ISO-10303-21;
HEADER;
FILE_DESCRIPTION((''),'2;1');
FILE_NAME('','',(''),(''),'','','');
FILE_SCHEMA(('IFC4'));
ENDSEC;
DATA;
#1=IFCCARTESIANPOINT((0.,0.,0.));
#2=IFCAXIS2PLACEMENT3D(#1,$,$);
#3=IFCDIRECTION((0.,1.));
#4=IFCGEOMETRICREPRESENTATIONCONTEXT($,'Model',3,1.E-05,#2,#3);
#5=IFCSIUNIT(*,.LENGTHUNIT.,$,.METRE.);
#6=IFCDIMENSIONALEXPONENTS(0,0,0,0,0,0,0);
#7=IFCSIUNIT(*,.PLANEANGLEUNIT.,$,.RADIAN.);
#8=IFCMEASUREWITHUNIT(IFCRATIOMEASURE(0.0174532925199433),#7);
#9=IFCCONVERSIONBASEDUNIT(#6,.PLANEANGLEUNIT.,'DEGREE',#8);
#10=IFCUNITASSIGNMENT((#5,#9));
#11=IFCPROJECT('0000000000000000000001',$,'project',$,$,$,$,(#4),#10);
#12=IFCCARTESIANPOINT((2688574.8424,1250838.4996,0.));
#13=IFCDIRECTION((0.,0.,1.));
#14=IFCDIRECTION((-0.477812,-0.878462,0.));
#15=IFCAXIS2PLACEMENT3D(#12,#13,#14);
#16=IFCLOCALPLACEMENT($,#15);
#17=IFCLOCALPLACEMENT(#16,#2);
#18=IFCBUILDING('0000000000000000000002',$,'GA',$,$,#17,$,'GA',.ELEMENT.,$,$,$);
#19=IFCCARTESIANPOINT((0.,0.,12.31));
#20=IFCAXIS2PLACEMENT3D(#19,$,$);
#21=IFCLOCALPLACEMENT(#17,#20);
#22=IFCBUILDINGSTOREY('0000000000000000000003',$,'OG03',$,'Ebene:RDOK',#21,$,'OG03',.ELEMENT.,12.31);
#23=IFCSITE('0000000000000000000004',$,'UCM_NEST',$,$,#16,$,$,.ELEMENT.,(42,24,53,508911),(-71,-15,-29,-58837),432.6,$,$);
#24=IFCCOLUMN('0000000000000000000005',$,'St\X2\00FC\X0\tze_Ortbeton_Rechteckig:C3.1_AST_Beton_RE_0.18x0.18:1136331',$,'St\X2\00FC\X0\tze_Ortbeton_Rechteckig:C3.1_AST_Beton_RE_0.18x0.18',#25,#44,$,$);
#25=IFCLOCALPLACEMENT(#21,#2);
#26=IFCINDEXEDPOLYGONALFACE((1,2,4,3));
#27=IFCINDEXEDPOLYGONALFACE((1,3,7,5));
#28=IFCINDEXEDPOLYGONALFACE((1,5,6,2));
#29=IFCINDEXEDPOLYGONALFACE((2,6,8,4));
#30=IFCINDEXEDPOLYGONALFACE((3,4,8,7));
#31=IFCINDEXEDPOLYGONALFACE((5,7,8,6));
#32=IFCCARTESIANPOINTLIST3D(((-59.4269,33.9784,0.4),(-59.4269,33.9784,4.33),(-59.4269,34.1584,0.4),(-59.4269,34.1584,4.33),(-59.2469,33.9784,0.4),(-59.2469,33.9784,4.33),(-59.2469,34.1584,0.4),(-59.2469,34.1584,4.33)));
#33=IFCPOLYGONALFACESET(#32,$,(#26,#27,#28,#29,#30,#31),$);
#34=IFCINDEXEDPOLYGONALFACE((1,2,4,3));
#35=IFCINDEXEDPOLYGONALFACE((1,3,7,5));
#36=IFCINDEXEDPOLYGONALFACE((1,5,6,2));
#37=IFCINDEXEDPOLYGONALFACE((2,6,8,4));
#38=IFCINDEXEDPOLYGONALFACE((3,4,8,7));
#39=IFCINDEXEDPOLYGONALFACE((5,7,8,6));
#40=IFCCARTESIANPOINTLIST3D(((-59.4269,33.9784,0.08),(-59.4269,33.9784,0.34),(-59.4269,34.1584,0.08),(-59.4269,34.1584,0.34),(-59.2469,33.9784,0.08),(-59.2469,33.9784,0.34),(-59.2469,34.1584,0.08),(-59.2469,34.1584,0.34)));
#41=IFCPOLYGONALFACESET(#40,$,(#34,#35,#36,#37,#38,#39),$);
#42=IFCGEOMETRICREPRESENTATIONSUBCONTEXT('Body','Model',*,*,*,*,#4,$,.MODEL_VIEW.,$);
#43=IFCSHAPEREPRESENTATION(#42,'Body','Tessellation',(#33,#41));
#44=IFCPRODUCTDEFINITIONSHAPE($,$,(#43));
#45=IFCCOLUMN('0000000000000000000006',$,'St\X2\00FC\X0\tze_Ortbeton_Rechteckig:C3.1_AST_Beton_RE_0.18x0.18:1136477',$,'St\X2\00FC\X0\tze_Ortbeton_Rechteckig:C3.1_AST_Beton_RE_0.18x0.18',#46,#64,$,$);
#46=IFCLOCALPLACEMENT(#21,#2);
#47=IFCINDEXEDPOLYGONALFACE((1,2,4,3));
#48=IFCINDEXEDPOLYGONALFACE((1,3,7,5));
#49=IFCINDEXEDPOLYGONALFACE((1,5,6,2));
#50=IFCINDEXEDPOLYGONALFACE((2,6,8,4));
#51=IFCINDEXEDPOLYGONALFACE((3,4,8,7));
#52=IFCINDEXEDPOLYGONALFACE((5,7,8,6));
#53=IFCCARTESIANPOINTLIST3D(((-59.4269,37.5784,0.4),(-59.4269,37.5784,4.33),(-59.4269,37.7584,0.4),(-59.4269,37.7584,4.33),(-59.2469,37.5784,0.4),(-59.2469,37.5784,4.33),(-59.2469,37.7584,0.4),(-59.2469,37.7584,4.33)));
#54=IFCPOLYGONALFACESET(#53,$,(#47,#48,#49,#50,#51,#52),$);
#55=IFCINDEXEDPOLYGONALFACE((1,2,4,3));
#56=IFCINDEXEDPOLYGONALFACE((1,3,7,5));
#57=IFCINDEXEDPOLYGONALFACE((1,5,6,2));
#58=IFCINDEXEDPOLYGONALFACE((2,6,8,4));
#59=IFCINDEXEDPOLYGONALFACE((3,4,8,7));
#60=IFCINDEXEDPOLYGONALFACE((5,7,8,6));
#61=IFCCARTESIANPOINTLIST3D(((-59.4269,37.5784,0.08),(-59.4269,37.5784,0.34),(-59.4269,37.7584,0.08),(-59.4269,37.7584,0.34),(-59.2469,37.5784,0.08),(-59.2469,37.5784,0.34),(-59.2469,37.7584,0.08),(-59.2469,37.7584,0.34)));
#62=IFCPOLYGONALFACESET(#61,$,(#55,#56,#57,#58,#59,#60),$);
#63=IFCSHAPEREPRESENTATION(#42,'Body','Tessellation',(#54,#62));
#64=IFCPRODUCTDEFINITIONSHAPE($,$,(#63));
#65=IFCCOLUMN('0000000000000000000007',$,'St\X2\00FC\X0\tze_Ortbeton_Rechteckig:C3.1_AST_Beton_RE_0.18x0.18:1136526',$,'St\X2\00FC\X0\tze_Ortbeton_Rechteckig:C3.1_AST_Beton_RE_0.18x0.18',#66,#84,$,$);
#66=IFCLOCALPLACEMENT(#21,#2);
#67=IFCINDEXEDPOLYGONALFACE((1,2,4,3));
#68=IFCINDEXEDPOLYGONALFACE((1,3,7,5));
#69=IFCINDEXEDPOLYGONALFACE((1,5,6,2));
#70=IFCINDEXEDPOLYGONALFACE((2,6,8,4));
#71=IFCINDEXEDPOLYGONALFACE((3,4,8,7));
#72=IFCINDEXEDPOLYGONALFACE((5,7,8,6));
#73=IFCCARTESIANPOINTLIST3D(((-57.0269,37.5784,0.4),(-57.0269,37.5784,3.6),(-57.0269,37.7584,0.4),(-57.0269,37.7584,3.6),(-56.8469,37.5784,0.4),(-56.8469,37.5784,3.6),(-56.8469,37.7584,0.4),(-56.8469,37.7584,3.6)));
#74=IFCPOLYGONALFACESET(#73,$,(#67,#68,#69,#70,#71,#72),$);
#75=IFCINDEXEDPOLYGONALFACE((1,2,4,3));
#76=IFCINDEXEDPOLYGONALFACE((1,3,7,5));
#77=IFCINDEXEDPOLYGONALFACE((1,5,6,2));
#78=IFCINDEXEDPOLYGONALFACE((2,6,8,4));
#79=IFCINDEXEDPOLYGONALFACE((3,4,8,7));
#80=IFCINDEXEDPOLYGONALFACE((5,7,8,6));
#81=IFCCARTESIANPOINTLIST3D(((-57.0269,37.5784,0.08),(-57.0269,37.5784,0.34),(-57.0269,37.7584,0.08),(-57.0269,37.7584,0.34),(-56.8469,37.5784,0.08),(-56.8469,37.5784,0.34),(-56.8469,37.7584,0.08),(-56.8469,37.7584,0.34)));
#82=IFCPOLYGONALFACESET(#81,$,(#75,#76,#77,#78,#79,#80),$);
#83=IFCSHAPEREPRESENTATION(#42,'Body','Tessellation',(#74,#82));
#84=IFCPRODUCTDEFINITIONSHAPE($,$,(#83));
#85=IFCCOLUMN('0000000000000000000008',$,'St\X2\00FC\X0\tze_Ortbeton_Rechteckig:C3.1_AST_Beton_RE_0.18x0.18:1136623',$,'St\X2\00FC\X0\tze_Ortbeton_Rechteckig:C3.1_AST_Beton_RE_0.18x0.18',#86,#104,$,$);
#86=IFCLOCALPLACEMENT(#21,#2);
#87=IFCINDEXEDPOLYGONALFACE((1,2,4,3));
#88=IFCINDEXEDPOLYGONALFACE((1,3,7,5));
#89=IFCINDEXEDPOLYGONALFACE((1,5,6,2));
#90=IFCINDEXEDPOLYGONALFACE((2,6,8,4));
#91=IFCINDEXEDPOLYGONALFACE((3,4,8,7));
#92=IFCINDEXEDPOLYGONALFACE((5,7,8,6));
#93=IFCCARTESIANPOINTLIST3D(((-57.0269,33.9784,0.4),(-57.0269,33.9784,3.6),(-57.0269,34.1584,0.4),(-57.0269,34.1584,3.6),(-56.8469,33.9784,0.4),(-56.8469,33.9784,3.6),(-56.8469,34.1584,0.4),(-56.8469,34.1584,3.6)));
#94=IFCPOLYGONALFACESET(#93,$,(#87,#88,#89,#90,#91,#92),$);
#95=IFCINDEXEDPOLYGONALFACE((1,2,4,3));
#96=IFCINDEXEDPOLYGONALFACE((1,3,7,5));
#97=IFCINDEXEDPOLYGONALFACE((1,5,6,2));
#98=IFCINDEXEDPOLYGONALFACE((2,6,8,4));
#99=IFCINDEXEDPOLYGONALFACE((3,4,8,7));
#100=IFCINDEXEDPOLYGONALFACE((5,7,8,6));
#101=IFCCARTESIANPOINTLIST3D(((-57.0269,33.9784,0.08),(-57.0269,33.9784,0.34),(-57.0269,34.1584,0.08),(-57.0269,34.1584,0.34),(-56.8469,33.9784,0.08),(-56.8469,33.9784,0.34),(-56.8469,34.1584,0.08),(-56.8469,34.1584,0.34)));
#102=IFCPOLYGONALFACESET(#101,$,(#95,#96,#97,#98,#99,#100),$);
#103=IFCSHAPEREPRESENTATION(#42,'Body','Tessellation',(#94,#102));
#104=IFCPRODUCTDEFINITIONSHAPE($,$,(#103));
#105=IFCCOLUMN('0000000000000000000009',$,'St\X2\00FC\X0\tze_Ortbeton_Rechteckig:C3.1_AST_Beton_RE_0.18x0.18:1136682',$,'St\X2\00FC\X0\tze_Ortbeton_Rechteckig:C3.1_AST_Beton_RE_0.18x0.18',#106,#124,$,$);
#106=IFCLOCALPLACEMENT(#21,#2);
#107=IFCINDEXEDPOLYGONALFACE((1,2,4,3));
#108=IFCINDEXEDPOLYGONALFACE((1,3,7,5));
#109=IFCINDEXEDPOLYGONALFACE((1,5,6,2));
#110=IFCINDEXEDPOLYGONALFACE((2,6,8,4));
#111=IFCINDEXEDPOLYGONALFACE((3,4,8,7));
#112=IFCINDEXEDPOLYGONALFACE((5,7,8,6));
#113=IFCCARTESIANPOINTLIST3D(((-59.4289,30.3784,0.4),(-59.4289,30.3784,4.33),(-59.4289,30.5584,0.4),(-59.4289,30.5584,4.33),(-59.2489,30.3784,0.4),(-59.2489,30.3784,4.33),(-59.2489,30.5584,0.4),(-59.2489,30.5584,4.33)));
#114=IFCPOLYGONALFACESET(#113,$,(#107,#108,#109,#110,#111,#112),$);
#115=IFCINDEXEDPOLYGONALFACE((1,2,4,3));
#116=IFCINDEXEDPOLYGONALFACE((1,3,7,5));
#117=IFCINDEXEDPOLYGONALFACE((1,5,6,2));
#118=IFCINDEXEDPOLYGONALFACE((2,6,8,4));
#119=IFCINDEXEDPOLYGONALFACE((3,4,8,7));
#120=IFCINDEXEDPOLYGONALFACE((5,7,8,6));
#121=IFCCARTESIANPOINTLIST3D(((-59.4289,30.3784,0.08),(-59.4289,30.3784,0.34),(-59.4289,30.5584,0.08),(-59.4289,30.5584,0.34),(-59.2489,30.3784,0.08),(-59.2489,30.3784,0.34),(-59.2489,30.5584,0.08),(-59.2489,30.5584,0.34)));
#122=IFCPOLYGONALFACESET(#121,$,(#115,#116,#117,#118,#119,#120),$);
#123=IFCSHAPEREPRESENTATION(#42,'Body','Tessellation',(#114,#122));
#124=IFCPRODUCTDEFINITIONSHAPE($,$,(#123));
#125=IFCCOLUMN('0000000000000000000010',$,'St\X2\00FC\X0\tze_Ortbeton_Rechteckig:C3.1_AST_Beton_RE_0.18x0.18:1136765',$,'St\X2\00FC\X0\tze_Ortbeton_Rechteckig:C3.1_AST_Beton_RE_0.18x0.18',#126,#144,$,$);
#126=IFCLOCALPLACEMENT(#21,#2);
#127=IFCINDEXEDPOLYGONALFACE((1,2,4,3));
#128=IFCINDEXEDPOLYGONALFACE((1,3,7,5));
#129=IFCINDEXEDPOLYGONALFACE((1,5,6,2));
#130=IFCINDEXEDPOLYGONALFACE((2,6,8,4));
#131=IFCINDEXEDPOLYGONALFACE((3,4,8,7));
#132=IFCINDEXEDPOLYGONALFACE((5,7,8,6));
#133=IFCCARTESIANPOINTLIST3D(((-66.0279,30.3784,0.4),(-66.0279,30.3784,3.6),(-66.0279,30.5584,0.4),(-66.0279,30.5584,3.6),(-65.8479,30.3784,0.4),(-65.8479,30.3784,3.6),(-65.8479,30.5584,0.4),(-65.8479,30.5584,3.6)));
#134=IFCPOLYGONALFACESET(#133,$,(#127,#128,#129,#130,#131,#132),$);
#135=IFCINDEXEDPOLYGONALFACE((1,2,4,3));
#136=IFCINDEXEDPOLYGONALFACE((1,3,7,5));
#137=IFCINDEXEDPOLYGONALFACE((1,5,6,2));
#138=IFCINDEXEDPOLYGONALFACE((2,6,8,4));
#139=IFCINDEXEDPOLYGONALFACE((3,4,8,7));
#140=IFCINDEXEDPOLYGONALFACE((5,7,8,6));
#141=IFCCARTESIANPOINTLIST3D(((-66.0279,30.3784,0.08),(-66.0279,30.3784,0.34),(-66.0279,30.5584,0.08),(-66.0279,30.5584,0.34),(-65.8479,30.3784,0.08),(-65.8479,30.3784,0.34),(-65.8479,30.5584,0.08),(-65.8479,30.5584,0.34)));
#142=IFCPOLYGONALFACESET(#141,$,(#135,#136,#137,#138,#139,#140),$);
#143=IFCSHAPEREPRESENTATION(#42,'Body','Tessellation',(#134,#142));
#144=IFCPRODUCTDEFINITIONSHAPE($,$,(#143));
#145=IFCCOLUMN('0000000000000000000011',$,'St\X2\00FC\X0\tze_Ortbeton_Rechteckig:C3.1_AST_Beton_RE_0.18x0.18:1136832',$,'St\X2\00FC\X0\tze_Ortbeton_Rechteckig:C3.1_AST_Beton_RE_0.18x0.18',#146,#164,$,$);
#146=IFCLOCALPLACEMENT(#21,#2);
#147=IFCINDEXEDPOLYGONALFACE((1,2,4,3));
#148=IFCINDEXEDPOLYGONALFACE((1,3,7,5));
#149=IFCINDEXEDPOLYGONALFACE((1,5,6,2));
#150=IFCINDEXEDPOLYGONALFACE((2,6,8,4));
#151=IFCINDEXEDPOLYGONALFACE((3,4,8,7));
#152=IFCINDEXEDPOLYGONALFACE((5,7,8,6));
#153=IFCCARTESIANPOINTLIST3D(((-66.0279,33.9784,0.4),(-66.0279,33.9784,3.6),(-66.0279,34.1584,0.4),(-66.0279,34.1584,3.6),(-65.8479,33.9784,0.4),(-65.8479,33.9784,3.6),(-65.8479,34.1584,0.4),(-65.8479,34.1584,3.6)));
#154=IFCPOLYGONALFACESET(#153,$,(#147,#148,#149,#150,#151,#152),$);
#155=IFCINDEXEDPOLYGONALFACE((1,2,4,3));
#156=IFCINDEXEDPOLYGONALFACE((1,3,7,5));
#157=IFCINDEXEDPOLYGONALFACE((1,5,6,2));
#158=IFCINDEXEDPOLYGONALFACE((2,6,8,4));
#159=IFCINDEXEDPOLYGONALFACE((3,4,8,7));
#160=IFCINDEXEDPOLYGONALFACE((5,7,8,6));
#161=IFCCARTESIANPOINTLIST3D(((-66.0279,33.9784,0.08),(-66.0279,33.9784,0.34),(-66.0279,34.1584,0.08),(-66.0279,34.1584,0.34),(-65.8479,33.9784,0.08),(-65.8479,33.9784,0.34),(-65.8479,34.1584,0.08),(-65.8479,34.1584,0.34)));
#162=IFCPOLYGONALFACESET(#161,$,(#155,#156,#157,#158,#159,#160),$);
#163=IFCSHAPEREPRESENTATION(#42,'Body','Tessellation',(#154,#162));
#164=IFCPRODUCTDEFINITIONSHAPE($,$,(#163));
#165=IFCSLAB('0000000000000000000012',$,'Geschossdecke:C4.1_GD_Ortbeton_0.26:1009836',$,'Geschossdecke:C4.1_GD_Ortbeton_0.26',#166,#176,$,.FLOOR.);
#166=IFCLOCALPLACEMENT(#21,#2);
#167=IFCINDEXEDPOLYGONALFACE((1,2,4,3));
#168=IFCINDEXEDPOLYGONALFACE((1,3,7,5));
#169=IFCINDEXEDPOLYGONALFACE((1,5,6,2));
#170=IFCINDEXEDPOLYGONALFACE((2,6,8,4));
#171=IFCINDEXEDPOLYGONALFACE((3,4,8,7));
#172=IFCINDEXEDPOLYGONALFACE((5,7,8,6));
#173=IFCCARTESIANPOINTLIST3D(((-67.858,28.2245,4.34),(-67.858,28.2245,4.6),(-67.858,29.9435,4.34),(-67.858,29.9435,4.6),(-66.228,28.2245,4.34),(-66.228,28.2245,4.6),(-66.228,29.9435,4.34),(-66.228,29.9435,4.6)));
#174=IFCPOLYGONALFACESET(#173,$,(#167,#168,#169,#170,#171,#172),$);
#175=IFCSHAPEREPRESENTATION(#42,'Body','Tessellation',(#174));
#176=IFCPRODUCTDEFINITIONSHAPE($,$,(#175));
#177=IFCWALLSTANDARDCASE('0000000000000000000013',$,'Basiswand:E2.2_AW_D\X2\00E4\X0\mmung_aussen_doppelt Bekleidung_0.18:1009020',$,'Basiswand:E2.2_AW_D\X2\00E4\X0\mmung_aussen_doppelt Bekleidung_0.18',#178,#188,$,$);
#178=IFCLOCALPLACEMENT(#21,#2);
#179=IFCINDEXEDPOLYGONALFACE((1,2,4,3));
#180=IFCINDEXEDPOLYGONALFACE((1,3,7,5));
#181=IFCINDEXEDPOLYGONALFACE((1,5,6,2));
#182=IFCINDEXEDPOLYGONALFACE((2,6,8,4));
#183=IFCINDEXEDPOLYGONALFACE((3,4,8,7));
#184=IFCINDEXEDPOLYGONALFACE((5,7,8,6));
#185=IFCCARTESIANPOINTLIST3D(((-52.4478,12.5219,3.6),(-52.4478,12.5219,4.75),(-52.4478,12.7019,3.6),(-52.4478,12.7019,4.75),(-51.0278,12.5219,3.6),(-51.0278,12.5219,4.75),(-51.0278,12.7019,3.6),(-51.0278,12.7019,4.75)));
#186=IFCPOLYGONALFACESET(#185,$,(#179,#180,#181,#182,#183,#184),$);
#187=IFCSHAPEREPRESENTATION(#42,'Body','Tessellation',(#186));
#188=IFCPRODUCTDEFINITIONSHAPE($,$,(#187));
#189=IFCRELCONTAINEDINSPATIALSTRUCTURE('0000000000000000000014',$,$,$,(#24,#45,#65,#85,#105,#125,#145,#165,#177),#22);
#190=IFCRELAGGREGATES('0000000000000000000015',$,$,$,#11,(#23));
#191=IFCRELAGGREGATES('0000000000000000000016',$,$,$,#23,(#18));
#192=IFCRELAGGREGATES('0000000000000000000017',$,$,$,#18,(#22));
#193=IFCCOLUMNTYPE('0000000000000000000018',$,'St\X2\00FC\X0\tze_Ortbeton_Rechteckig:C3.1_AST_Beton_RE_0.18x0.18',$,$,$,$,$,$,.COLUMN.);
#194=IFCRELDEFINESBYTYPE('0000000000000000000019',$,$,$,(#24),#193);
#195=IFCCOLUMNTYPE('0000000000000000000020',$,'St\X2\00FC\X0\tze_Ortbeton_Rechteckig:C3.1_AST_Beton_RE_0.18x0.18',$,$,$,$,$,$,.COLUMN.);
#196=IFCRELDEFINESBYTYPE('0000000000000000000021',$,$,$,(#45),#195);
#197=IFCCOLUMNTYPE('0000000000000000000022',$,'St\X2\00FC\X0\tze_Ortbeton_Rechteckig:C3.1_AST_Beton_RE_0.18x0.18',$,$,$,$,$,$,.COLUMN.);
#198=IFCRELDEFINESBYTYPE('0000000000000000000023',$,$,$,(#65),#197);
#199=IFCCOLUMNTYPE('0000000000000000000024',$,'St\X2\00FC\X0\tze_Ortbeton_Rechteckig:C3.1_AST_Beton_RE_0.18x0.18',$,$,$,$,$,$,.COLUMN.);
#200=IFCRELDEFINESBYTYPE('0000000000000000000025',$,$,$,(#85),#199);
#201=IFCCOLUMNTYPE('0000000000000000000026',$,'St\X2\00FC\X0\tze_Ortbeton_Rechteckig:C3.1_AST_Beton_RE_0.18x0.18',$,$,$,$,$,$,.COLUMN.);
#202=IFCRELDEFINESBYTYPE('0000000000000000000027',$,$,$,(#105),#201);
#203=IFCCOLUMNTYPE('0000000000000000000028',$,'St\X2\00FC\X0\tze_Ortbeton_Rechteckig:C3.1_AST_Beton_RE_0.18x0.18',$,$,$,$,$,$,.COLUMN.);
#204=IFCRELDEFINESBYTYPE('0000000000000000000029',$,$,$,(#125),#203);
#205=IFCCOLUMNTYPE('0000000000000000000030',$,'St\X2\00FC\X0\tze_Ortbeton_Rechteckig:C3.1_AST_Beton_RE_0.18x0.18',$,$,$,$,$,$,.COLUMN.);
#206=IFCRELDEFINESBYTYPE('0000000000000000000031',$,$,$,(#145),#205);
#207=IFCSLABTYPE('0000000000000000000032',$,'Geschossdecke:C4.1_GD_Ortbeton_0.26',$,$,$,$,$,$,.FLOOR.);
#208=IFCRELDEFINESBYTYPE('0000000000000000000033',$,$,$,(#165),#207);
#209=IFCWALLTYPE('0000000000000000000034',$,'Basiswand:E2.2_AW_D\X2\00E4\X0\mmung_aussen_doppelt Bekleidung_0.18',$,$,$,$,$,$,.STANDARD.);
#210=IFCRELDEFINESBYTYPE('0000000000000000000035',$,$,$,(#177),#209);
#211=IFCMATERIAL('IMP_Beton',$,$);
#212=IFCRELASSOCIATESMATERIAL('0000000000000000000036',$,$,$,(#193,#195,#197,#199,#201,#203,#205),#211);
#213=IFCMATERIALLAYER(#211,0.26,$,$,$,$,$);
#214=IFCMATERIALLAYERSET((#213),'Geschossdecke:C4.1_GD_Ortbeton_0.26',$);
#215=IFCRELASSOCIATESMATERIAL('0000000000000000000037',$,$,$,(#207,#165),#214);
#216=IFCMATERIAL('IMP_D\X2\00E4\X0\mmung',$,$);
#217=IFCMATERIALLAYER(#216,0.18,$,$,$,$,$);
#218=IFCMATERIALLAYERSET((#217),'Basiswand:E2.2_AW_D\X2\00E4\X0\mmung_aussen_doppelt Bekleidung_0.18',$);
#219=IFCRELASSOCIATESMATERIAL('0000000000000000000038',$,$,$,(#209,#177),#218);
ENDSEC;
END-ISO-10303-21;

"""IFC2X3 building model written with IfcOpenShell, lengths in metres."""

from ifc_helpers import new_model, entity, si_unit, converted_unit, direction, frame, frame_2d, origin, origin_2d_with_axis, place, context, subcontext, project, spatial, rectangle, extrude, source, transform, mapped, material, layer, layer_set, layer_usage, type_object, type_shapes, element, save


model = new_model("IFC2X3")

# Units and contexts
model_context = context("Model", 3, precision=1e-05, world=origin(), true_north=direction((0.0, 1.0)))
body_context = subcontext(model_context, "Body", "Model", "MODEL_VIEW")
ifc_project = project(units=[si_unit("LENGTHUNIT", "METRE"), converted_unit("PLANEANGLEUNIT", "DEGREE", entity("IfcRatioMeasure", 0.0174532925199433), si_unit("PLANEANGLEUNIT", "RADIAN"), dimensions=[0, 0, 0, 0, 0, 0, 0])], contexts=[model_context])

# Site, building, storey
site_placement = place(None, frame((2688574.8424, 1250838.4996, 0.0), z_axis=(0.0, 0.0, 1.0), x_axis=(-0.477812, -0.878462, 0.0)))
site = spatial("IfcSite", under=ifc_project, at=site_placement, Name="UCM_NEST", CompositionType="ELEMENT", RefLatitude=(42, 24, 53, 508911), RefLongitude=(-71, -15, -29, -58837), RefElevation=432.6)
building_placement = place(site_placement, origin())
building = spatial("IfcBuilding", under=site, at=building_placement, Name="GA", LongName="GA", CompositionType="ELEMENT")
storey_placement = place(building_placement, frame((0.0, 0.0, 12.31)))
storey = spatial("IfcBuildingStorey", under=building, at=storey_placement, Name="OG03", ObjectType="Ebene:RDOK", LongName="OG03", CompositionType="ELEMENT", Elevation=12.31)

# Columns
ifc_material_1 = material(Name="IMP_Beton")
column_type_1 = type_object("IfcColumnType", Name="Stütze_Ortbeton_Rechteckig:C3.1_AST_Beton_RE_0.18x0.18", PredefinedType="COLUMN", material=ifc_material_1)
shared_shape_1 = source(origin(), body_context, "Body", "SweptSolid", [
    extrude(rectangle(XDim=0.18, YDim=0.18, at=frame_2d((0.0, 0.0), x_axis=(1.0, 0.0))), frame((-59.3369, 34.0684, 12.71), z_axis=(0.0, 0.0, 1.0), x_axis=(0.0, -1.0, 0.0)), (0.0, 0.0, 1.0), 3.93),
    extrude(rectangle(XDim=0.18, YDim=0.18, at=frame_2d((0.0, 0.0), x_axis=(1.0, 0.0))), frame((-59.3369, 34.0684, 12.39), z_axis=(0.0, 0.0, 1.0), x_axis=(0.0, -1.0, 0.0)), (0.0, 0.0, 1.0), 0.26),
])
type_shapes(column_type_1, [shared_shape_1])
column_1_placement = place(storey_placement, frame((0.0, 0.0, -12.31)))
element("IfcColumn", 1, at=column_1_placement, inside=storey, type_object=column_type_1, Name="Stütze_Ortbeton_Rechteckig:C3.1_AST_Beton_RE_0.18x0.18:1136331", ObjectType="Stütze_Ortbeton_Rechteckig:C3.1_AST_Beton_RE_0.18x0.18", context=body_context, shape_type="MappedRepresentation", body=[
    mapped(shared_shape_1, transform((0.0, 0.0, 0.0), scale=1.0)),
])
column_type_2 = type_object("IfcColumnType", Name="Stütze_Ortbeton_Rechteckig:C3.1_AST_Beton_RE_0.18x0.18", PredefinedType="COLUMN", material=ifc_material_1)
shared_shape_2 = source(origin(), body_context, "Body", "SweptSolid", [
    extrude(rectangle(XDim=0.18, YDim=0.18, at=frame_2d((0.0, 0.0), x_axis=(1.0, 0.0))), frame((-59.3369, 37.6684, 12.71), z_axis=(0.0, 0.0, 1.0), x_axis=(0.0, -1.0, 0.0)), (0.0, 0.0, 1.0), 3.93),
    extrude(rectangle(XDim=0.18, YDim=0.18, at=frame_2d((0.0, 0.0), x_axis=(1.0, 0.0))), frame((-59.3369, 37.6684, 12.39), z_axis=(0.0, 0.0, 1.0), x_axis=(0.0, -1.0, 0.0)), (0.0, 0.0, 1.0), 0.26),
])
type_shapes(column_type_2, [shared_shape_2])
column_2_placement = place(storey_placement, frame((0.0, 0.0, -12.31)))
element("IfcColumn", 2, at=column_2_placement, inside=storey, type_object=column_type_2, Name="Stütze_Ortbeton_Rechteckig:C3.1_AST_Beton_RE_0.18x0.18:1136477", ObjectType="Stütze_Ortbeton_Rechteckig:C3.1_AST_Beton_RE_0.18x0.18", context=body_context, shape_type="MappedRepresentation", body=[
    mapped(shared_shape_2, transform((0.0, 0.0, 0.0), scale=1.0)),
])
column_type_3 = type_object("IfcColumnType", Name="Stütze_Ortbeton_Rechteckig:C3.1_AST_Beton_RE_0.18x0.18", PredefinedType="COLUMN", material=ifc_material_1)
shared_shape_3 = source(origin(), body_context, "Body", "SweptSolid", [
    extrude(rectangle(XDim=0.18, YDim=0.18, at=origin_2d_with_axis()), frame((-56.9369, 37.6684, 12.71), z_axis=(0.0, 0.0, 1.0), x_axis=(0.0, -1.0, 0.0)), (0.0, 0.0, 1.0), 3.2),
    extrude(rectangle(XDim=0.18, YDim=0.18, at=origin_2d_with_axis()), frame((-56.9369, 37.6684, 12.39), z_axis=(0.0, 0.0, 1.0), x_axis=(0.0, -1.0, 0.0)), (0.0, 0.0, 1.0), 0.26),
])
type_shapes(column_type_3, [shared_shape_3])
column_3_placement = place(storey_placement, frame((0.0, 0.0, -12.31)))
element("IfcColumn", 3, at=column_3_placement, inside=storey, type_object=column_type_3, Name="Stütze_Ortbeton_Rechteckig:C3.1_AST_Beton_RE_0.18x0.18:1136526", ObjectType="Stütze_Ortbeton_Rechteckig:C3.1_AST_Beton_RE_0.18x0.18", context=body_context, shape_type="MappedRepresentation", body=[
    mapped(shared_shape_3, transform((0.0, 0.0, 0.0), scale=1.0)),
])
column_type_4 = type_object("IfcColumnType", Name="Stütze_Ortbeton_Rechteckig:C3.1_AST_Beton_RE_0.18x0.18", PredefinedType="COLUMN", material=ifc_material_1)
shared_shape_4 = source(origin(), body_context, "Body", "SweptSolid", [
    extrude(rectangle(XDim=0.18, YDim=0.18, at=frame_2d((0.0, 0.0), x_axis=(1.0, 0.0))), frame((-56.9369, 34.0684, 12.71), z_axis=(0.0, 0.0, 1.0), x_axis=(0.0, -1.0, 0.0)), (0.0, 0.0, 1.0), 3.2),
    extrude(rectangle(XDim=0.18, YDim=0.18, at=frame_2d((0.0, 0.0), x_axis=(1.0, 0.0))), frame((-56.9369, 34.0684, 12.39), z_axis=(0.0, 0.0, 1.0), x_axis=(0.0, -1.0, 0.0)), (0.0, 0.0, 1.0), 0.26),
])
type_shapes(column_type_4, [shared_shape_4])
column_4_placement = place(storey_placement, frame((0.0, 0.0, -12.31)))
element("IfcColumn", 4, at=column_4_placement, inside=storey, type_object=column_type_4, Name="Stütze_Ortbeton_Rechteckig:C3.1_AST_Beton_RE_0.18x0.18:1136623", ObjectType="Stütze_Ortbeton_Rechteckig:C3.1_AST_Beton_RE_0.18x0.18", context=body_context, shape_type="MappedRepresentation", body=[
    mapped(shared_shape_4, transform((0.0, 0.0, 0.0), scale=1.0)),
])
column_type_5 = type_object("IfcColumnType", Name="Stütze_Ortbeton_Rechteckig:C3.1_AST_Beton_RE_0.18x0.18", PredefinedType="COLUMN", material=ifc_material_1)
shared_shape_5 = source(origin(), body_context, "Body", "SweptSolid", [
    extrude(rectangle(XDim=0.18, YDim=0.18, at=frame_2d((0.0, 0.0), x_axis=(1.0, 0.0))), frame((-59.3389, 30.4684, 12.71), z_axis=(0.0, 0.0, 1.0), x_axis=(0.0, -1.0, 0.0)), (0.0, 0.0, 1.0), 3.93),
    extrude(rectangle(XDim=0.18, YDim=0.18, at=frame_2d((0.0, 0.0), x_axis=(1.0, 0.0))), frame((-59.3389, 30.4684, 12.39), z_axis=(0.0, 0.0, 1.0), x_axis=(0.0, -1.0, 0.0)), (0.0, 0.0, 1.0), 0.26),
])
type_shapes(column_type_5, [shared_shape_5])
column_5_placement = place(storey_placement, frame((0.0, 0.0, -12.31)))
element("IfcColumn", 5, at=column_5_placement, inside=storey, type_object=column_type_5, Name="Stütze_Ortbeton_Rechteckig:C3.1_AST_Beton_RE_0.18x0.18:1136682", ObjectType="Stütze_Ortbeton_Rechteckig:C3.1_AST_Beton_RE_0.18x0.18", context=body_context, shape_type="MappedRepresentation", body=[
    mapped(shared_shape_5, transform((0.0, 0.0, 0.0), scale=1.0)),
])
column_type_6 = type_object("IfcColumnType", Name="Stütze_Ortbeton_Rechteckig:C3.1_AST_Beton_RE_0.18x0.18", PredefinedType="COLUMN", material=ifc_material_1)
shared_shape_6 = source(origin(), body_context, "Body", "SweptSolid", [
    extrude(rectangle(XDim=0.18, YDim=0.18, at=origin_2d_with_axis()), frame((-65.9379, 30.4684, 12.71), z_axis=(0.0, 0.0, 1.0), x_axis=(0.0, -1.0, 0.0)), (0.0, 0.0, 1.0), 3.2),
    extrude(rectangle(XDim=0.18, YDim=0.18, at=origin_2d_with_axis()), frame((-65.9379, 30.4684, 12.39), z_axis=(0.0, 0.0, 1.0), x_axis=(0.0, -1.0, 0.0)), (0.0, 0.0, 1.0), 0.26),
])
type_shapes(column_type_6, [shared_shape_6])
column_6_placement = place(storey_placement, frame((0.0, 0.0, -12.31)))
element("IfcColumn", 6, at=column_6_placement, inside=storey, type_object=column_type_6, Name="Stütze_Ortbeton_Rechteckig:C3.1_AST_Beton_RE_0.18x0.18:1136765", ObjectType="Stütze_Ortbeton_Rechteckig:C3.1_AST_Beton_RE_0.18x0.18", context=body_context, shape_type="MappedRepresentation", body=[
    mapped(shared_shape_6, transform((0.0, 0.0, 0.0), scale=1.0)),
])
column_type_7 = type_object("IfcColumnType", Name="Stütze_Ortbeton_Rechteckig:C3.1_AST_Beton_RE_0.18x0.18", PredefinedType="COLUMN", material=ifc_material_1)
shared_shape_7 = source(origin(), body_context, "Body", "SweptSolid", [
    extrude(rectangle(XDim=0.18, YDim=0.18, at=origin_2d_with_axis()), frame((-65.9379, 34.0684, 12.71), z_axis=(0.0, 0.0, 1.0), x_axis=(0.0, -1.0, 0.0)), (0.0, 0.0, 1.0), 3.2),
    extrude(rectangle(XDim=0.18, YDim=0.18, at=origin_2d_with_axis()), frame((-65.9379, 34.0684, 12.39), z_axis=(0.0, 0.0, 1.0), x_axis=(0.0, -1.0, 0.0)), (0.0, 0.0, 1.0), 0.26),
])
type_shapes(column_type_7, [shared_shape_7])
column_7_placement = place(storey_placement, frame((0.0, 0.0, -12.31)))
element("IfcColumn", 7, at=column_7_placement, inside=storey, type_object=column_type_7, Name="Stütze_Ortbeton_Rechteckig:C3.1_AST_Beton_RE_0.18x0.18:1136832", ObjectType="Stütze_Ortbeton_Rechteckig:C3.1_AST_Beton_RE_0.18x0.18", context=body_context, shape_type="MappedRepresentation", body=[
    mapped(shared_shape_7, transform((0.0, 0.0, 0.0), scale=1.0)),
])

# Slab
ifc_layer_1 = layer(ifc_material_1, 0.26)
ifc_layer_set_1 = layer_set([ifc_layer_1], Name="Geschossdecke:C4.1_GD_Ortbeton_0.26")
ifc_layer_usage_1 = layer_usage(ifc_layer_set_1, "AXIS3", "POSITIVE", 0.0)
slab_type_1 = type_object("IfcSlabType", Name="Geschossdecke:C4.1_GD_Ortbeton_0.26", PredefinedType="FLOOR", material=ifc_layer_set_1)
slab_1_placement = place(storey_placement, origin())
element("IfcSlab", 8, at=slab_1_placement, inside=storey, type_object=slab_type_1, material=ifc_layer_usage_1, Name="Geschossdecke:C4.1_GD_Ortbeton_0.26:1009836", ObjectType="Geschossdecke:C4.1_GD_Ortbeton_0.26", PredefinedType="FLOOR", context=body_context, shape_type="SweptSolid", body=[
    extrude(rectangle(XDim=1.719, YDim=1.63, at=frame_2d((0.0, 0.0), x_axis=(1.0, 0.0))), frame((-67.043, 29.084, 4.6), z_axis=(0.0, 0.0, -1.0), x_axis=(0.0, 1.0, 0.0)), (0.0, 0.0, 1.0), 0.26),
])
ifc_material_2 = material(Name="IMP_Dämmung")

# Wall
ifc_layer_2 = layer(ifc_material_2, 0.18)
ifc_layer_set_2 = layer_set([ifc_layer_2], Name="Basiswand:E2.2_AW_Dämmung_aussen_doppelt Bekleidung_0.18")
ifc_layer_usage_2 = layer_usage(ifc_layer_set_2, "AXIS2", "NEGATIVE", 0.09)
wall_type_1 = type_object("IfcWallType", Name="Basiswand:E2.2_AW_Dämmung_aussen_doppelt Bekleidung_0.18", PredefinedType="STANDARD", material=ifc_layer_set_2)
wall_1_placement = place(storey_placement, frame((-52.4478, 12.6119, 3.6)))
element("IfcWallStandardCase", 9, at=wall_1_placement, inside=storey, type_object=wall_type_1, material=ifc_layer_usage_2, Name="Basiswand:E2.2_AW_Dämmung_aussen_doppelt Bekleidung_0.18:1009020", ObjectType="Basiswand:E2.2_AW_Dämmung_aussen_doppelt Bekleidung_0.18", context=body_context, shape_type="SweptSolid", body=[
    extrude(rectangle(XDim=1.42, YDim=0.18, at=frame_2d((0.71, 0.0), x_axis=(-1.0, 0.0))), origin(), (0.0, 0.0, 1.0), 1.15),
])

save(model, "model.ifc")
